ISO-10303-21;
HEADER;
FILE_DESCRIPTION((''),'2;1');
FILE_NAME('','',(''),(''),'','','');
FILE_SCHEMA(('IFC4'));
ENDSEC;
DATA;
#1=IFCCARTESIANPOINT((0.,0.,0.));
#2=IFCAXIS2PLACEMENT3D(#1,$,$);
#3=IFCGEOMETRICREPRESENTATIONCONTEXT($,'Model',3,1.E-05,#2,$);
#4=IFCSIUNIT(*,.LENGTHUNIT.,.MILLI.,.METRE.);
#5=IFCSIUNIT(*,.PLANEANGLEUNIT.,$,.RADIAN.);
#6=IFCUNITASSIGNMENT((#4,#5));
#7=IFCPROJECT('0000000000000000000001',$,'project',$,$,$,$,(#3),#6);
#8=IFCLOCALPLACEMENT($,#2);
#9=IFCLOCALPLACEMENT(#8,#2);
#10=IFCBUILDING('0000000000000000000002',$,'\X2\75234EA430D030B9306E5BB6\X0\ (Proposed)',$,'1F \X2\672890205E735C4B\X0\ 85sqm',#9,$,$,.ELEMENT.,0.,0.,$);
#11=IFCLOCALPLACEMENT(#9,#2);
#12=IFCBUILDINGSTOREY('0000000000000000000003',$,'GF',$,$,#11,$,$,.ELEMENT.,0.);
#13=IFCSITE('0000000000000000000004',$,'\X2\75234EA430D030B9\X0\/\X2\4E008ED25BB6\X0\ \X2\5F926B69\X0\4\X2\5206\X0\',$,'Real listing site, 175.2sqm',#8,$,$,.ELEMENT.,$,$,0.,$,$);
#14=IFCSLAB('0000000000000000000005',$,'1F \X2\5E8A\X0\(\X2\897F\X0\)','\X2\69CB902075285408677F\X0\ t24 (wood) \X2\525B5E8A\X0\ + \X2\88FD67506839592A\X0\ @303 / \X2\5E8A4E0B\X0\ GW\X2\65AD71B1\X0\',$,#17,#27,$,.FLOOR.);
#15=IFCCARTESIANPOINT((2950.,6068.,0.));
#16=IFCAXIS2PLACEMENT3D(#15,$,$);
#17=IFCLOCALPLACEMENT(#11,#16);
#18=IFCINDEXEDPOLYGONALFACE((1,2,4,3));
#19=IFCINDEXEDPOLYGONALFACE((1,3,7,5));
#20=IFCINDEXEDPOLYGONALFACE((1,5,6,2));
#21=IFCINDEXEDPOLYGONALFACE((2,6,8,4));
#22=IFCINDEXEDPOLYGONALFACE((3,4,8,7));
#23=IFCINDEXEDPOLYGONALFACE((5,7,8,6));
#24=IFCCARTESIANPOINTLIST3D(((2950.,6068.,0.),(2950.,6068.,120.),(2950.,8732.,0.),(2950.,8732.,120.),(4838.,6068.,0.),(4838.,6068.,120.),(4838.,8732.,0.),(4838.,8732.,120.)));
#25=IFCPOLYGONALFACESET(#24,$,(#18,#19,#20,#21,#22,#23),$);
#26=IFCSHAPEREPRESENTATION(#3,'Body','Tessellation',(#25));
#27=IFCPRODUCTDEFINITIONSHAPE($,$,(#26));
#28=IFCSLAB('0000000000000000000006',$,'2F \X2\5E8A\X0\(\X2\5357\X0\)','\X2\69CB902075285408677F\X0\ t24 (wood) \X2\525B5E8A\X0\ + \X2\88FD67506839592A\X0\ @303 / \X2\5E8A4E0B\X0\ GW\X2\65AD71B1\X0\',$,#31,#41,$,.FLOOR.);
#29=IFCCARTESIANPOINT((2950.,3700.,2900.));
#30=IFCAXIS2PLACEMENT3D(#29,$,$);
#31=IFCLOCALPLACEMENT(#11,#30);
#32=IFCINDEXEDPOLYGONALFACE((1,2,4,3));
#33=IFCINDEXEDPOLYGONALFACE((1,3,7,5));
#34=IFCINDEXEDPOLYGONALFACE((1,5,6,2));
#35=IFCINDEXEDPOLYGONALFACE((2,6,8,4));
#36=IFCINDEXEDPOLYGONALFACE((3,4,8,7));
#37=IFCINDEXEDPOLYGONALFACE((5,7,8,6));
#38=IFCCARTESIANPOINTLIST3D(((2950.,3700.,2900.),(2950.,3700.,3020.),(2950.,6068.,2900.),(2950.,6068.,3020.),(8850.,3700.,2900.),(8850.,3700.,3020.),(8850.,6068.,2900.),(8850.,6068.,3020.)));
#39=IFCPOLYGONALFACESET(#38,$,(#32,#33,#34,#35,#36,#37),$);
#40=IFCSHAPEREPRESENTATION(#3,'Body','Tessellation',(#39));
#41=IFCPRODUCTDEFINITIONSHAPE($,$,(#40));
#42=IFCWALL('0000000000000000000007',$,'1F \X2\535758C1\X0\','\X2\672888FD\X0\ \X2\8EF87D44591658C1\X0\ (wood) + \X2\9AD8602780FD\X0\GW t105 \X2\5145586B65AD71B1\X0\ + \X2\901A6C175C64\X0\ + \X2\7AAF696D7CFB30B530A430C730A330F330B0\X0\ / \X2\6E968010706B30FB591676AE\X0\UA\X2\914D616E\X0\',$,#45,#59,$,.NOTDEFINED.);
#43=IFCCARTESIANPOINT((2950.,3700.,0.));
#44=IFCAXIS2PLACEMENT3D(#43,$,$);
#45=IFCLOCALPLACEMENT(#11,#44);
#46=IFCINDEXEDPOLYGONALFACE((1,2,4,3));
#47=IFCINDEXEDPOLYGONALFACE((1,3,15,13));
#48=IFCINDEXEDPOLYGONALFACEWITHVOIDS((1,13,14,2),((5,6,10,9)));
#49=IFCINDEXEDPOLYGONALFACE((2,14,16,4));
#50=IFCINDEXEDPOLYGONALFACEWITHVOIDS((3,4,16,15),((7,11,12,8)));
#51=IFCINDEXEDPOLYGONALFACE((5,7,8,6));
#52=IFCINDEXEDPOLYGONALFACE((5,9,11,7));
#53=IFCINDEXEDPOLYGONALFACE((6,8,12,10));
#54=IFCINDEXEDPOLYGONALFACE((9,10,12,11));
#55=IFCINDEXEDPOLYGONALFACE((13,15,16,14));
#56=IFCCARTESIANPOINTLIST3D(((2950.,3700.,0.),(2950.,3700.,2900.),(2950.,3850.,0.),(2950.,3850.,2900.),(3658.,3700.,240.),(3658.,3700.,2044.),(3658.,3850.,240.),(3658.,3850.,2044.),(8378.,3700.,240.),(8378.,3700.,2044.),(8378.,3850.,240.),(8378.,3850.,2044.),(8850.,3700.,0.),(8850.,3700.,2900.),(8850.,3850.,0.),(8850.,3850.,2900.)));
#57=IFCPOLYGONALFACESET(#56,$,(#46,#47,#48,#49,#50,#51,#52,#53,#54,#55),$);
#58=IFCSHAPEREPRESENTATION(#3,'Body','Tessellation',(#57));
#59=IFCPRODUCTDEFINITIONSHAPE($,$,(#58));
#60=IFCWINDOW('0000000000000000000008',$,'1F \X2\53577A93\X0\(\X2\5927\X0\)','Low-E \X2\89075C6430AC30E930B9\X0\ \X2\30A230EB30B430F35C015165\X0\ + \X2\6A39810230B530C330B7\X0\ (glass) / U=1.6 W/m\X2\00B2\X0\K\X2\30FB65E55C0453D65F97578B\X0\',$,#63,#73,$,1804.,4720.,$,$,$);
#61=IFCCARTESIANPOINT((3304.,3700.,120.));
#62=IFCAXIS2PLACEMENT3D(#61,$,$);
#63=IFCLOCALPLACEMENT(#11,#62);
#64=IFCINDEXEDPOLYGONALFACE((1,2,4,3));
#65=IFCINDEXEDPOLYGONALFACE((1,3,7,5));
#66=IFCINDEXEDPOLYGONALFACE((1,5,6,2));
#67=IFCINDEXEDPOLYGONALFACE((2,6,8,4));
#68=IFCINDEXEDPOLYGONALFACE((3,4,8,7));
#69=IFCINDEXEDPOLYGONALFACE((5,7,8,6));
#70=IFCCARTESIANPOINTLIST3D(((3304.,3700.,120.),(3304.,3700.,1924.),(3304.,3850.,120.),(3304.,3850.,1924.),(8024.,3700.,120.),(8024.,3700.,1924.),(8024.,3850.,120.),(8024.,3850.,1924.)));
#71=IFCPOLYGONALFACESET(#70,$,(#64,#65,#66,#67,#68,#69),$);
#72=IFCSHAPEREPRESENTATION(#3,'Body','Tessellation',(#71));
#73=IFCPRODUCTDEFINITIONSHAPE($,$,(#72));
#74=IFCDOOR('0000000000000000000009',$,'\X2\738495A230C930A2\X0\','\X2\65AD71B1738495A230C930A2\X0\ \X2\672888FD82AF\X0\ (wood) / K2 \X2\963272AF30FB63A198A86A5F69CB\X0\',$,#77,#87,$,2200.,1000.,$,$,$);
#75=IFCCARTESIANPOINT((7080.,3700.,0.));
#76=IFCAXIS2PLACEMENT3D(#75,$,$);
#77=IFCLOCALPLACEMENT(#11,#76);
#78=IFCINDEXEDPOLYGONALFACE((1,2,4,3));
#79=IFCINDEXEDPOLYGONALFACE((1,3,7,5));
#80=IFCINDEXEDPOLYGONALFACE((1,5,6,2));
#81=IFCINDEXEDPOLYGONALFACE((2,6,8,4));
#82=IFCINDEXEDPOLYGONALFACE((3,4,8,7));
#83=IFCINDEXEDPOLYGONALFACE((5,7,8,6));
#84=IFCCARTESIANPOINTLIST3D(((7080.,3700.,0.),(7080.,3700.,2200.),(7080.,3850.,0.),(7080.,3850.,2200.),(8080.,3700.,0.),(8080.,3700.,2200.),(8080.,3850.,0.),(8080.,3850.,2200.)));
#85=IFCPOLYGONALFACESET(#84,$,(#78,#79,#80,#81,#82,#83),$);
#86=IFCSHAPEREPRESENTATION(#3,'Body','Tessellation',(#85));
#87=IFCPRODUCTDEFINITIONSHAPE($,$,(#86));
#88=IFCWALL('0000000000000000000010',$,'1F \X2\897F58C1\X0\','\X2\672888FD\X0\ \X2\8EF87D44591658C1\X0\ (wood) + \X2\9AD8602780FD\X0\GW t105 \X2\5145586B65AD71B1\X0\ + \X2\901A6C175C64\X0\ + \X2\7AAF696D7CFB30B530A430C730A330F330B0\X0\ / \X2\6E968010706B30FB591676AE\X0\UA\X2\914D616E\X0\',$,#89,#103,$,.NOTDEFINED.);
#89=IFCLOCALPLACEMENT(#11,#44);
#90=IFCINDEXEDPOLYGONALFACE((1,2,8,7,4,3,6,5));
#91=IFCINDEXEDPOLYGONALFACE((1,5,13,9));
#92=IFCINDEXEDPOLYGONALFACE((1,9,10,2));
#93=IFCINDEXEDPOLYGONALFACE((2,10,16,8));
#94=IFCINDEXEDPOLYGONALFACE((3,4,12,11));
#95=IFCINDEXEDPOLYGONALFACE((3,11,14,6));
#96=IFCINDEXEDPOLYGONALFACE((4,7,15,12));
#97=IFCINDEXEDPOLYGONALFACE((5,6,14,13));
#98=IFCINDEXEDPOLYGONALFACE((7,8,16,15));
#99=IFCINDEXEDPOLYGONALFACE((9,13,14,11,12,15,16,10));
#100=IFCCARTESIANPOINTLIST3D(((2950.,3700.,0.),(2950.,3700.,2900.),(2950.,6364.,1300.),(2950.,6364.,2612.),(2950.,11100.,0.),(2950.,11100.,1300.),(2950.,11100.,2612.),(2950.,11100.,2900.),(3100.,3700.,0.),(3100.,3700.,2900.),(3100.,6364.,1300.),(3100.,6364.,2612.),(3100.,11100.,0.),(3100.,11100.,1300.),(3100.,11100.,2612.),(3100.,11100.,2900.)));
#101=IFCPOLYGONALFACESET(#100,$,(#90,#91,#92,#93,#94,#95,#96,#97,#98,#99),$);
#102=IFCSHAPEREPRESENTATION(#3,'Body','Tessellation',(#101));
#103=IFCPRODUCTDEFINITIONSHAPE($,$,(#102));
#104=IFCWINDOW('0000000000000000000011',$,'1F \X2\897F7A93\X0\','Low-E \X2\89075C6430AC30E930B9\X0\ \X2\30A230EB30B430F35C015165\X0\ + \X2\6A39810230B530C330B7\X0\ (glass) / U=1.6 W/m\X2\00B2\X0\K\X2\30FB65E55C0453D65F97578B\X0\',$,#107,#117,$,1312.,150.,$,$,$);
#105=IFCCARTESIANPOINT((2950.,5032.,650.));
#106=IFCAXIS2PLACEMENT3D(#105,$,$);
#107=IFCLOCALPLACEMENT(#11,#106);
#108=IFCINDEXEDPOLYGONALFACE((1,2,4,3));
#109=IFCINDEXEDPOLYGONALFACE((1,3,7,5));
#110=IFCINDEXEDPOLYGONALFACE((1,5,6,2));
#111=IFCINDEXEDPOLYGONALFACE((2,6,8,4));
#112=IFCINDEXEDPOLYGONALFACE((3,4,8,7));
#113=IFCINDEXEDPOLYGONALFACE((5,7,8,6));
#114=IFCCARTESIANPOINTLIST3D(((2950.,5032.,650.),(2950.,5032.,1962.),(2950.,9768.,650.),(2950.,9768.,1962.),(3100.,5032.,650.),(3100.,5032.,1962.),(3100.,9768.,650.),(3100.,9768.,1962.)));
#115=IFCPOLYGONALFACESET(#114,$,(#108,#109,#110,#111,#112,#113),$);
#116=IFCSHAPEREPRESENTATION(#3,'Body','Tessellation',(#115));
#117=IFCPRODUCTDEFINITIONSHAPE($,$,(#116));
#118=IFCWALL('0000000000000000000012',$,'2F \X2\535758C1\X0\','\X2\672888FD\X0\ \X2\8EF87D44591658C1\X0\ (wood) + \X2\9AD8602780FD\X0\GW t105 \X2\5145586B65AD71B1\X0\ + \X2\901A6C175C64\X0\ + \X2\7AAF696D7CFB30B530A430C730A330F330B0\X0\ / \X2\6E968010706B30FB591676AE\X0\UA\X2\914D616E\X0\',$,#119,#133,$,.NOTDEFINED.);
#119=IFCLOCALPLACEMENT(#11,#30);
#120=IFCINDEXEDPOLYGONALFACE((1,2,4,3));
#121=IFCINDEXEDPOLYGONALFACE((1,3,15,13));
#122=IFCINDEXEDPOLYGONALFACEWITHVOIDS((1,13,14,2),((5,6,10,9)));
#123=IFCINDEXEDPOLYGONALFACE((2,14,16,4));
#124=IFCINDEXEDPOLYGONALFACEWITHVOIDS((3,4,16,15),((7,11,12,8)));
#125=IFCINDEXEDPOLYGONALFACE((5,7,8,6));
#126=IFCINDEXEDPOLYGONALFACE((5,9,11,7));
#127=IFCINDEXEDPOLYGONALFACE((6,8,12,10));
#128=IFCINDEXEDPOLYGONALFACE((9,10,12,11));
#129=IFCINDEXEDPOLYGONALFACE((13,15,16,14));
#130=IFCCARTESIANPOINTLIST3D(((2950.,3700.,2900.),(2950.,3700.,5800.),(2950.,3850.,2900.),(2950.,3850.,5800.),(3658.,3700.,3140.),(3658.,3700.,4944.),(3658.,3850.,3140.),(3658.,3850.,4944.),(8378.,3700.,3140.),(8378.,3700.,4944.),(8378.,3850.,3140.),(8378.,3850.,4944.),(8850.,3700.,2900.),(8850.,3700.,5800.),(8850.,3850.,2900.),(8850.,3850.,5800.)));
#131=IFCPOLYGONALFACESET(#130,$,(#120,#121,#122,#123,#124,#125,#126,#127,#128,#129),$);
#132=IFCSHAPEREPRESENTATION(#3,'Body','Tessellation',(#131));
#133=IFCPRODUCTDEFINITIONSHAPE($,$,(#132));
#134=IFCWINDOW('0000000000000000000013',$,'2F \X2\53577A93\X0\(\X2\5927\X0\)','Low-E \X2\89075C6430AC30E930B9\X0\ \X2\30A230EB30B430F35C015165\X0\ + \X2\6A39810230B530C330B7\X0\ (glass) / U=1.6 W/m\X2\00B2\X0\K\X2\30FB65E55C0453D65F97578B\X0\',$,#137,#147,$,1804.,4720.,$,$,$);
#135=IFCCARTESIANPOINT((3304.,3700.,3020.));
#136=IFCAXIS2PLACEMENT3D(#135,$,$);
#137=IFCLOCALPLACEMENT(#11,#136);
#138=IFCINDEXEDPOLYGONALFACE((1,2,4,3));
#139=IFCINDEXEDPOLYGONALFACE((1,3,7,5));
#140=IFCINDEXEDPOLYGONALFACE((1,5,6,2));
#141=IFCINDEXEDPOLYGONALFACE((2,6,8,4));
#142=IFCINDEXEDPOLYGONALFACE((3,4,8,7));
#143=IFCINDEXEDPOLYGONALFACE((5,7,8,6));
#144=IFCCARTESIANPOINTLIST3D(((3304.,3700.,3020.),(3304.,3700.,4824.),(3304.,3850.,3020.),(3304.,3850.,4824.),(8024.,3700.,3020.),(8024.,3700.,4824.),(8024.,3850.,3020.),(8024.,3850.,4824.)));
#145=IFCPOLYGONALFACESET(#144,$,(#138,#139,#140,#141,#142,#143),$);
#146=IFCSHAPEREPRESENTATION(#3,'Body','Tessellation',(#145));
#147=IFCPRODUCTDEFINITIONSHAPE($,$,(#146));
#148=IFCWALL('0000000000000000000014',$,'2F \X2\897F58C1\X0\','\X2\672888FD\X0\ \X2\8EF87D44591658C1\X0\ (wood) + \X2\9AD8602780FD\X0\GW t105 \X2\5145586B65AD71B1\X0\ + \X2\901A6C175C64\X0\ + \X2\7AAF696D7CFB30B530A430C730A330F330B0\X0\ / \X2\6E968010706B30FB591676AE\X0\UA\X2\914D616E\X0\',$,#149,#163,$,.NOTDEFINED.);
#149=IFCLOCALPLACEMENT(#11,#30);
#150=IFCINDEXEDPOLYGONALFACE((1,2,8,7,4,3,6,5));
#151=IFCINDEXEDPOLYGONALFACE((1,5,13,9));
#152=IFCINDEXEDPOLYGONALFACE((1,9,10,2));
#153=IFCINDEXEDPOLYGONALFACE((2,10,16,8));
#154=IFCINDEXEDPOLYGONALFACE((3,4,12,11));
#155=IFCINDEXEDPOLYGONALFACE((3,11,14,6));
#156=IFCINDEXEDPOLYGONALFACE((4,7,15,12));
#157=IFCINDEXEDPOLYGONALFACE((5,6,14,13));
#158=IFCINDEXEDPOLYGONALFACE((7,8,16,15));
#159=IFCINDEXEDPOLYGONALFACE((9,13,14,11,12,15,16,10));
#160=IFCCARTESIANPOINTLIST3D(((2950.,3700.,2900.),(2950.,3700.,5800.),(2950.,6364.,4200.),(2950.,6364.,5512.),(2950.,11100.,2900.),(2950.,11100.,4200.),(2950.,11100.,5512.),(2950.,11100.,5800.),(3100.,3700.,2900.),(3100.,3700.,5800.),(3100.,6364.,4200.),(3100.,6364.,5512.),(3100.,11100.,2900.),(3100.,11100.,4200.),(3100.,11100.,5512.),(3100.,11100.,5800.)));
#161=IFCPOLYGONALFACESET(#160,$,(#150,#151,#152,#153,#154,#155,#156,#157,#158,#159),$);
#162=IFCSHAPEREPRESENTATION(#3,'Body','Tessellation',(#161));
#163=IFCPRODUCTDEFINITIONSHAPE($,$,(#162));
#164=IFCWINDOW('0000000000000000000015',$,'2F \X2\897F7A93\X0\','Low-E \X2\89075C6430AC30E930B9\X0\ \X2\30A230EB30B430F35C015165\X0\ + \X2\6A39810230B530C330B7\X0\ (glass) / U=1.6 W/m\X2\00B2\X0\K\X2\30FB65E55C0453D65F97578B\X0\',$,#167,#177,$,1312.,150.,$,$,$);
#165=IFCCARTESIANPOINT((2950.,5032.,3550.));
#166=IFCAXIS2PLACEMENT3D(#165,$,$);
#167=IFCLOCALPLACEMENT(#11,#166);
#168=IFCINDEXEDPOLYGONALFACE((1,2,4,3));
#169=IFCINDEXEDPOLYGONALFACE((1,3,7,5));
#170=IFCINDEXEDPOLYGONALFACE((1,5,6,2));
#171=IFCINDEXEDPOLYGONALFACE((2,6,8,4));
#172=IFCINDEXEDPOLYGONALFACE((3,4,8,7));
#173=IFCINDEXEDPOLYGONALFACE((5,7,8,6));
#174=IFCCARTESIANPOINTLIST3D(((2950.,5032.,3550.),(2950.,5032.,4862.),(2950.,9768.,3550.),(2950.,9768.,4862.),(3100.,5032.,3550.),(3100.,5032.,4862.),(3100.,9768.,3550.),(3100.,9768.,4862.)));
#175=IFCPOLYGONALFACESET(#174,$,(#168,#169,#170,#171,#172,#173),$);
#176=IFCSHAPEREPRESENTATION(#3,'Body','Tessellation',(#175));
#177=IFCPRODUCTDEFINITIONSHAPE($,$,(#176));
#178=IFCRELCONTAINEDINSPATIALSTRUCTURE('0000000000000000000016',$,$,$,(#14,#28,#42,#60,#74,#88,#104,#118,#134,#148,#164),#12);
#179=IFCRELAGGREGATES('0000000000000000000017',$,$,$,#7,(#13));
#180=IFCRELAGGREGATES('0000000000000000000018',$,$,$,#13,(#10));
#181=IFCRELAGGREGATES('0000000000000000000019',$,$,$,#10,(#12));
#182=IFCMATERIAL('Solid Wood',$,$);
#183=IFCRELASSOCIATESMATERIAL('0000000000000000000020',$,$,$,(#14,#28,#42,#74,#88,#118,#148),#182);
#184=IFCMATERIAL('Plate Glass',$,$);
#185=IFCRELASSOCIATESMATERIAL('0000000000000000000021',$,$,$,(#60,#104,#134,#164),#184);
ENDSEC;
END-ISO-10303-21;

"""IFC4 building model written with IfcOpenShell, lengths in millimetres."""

from ifc_helpers import new_model, si_unit, frame, frame_2d, origin, place, context, project, spatial, rectangle, extrude, material, element, fill, save


model = new_model("IFC4")

# Units and contexts
model_context = context("Model", 3, precision=1e-05, world=origin())
ifc_project = project(units=[si_unit("LENGTHUNIT", "METRE", prefix="MILLI"), si_unit("PLANEANGLEUNIT", "RADIAN")], contexts=[model_context])

# Site, building, storey
site_placement = place(None, origin())
site = spatial("IfcSite", under=ifc_project, at=site_placement, Name="産交バス/一軒家 徒歩4分", ObjectType="Real listing site, 175.2sqm", CompositionType="ELEMENT", RefElevation=0.0)
building_placement = place(site_placement, origin())
building = spatial("IfcBuilding", under=site, at=building_placement, Name="産交バスの家 (Proposed)", ObjectType="1F 木造平屋 85sqm", CompositionType="ELEMENT", ElevationOfRefHeight=0.0, ElevationOfTerrain=0.0)
storey_placement = place(building_placement, origin())
storey = spatial("IfcBuildingStorey", under=building, at=storey_placement, Name="GF", CompositionType="ELEMENT", Elevation=0.0)

# Slabs
ifc_material_1 = material(Name="Solid Wood")
slab_1_placement = place(storey_placement, frame((2950.0, 6068.0, 0.0)))
element("IfcSlab", 1, at=slab_1_placement, inside=storey, material=ifc_material_1, Name="1F 床(西)", Description="構造用合板 t24 (wood) 剛床 + 製材根太 @303 / 床下 GW断熱", PredefinedType="FLOOR", context=model_context, shape_type="SweptSolid", body=[
    extrude(rectangle(XDim=1888.0, YDim=2664.0, at=frame_2d((944.0, 1332.0))), frame((2950.0, 6068.0, 0.0)), (0.0, 0.0, 1.0), 120.0),
])
slab_2_placement = place(storey_placement, frame((2950.0, 3700.0, 2900.0)))
element("IfcSlab", 2, at=slab_2_placement, inside=storey, material=ifc_material_1, Name="2F 床(南)", Description="構造用合板 t24 (wood) 剛床 + 製材根太 @303 / 床下 GW断熱", PredefinedType="FLOOR", context=model_context, shape_type="SweptSolid", body=[
    extrude(rectangle(XDim=5900.0, YDim=2368.0, at=frame_2d((2950.0, 1184.0))), frame((2950.0, 3700.0, 2900.0)), (0.0, 0.0, 1.0), 120.0),
])

# Wall, openings, window, door
wall_1_placement = place(storey_placement, frame((2950.0, 3700.0, 0.0)))
wall_1 = element("IfcWall", 3, at=wall_1_placement, inside=storey, material=ifc_material_1, Name="1F 南壁", Description="木製 軸組外壁 (wood) + 高性能GW t105 充填断熱 + 通気層 + 窯業系サイディング / 準耐火・外皮UA配慮", PredefinedType="NOTDEFINED", context=model_context, shape_type="SweptSolid", body=[
    extrude(rectangle(XDim=5900.0, YDim=150.0, at=frame_2d((2950.0, 75.0))), frame((2950.0, 3700.0, 0.0)), (0.0, 0.0, 1.0), 2900.0),
])
opening_1_placement = place(storey_placement, frame((3304.0, 3700.0, 120.0)))
opening_1 = element("IfcOpeningElement", 4, at=opening_1_placement, cuts=wall_1, PredefinedType="NOTDEFINED", context=model_context, shape_type="SweptSolid", body=[
    extrude(rectangle(XDim=4720.0, YDim=150.0, at=frame_2d((2360.0, 75.0))), frame((3304.0, 3700.0, 120.0)), (0.0, 0.0, 1.0), 1804.0),
])
opening_2_placement = place(storey_placement, frame((7080.0, 3700.0, 0.0)))
opening_2 = element("IfcOpeningElement", 5, at=opening_2_placement, cuts=wall_1, PredefinedType="NOTDEFINED", context=model_context, shape_type="SweptSolid", body=[
    extrude(rectangle(XDim=1000.0, YDim=150.0, at=frame_2d((500.0, 75.0))), frame((7080.0, 3700.0, 0.0)), (0.0, 0.0, 1.0), 2200.0),
])
ifc_material_2 = material(Name="Plate Glass")
window_1_placement = place(storey_placement, frame((3304.0, 3700.0, 120.0)))
window_1 = element("IfcWindow", 6, at=window_1_placement, inside=storey, material=ifc_material_2, Name="1F 南窓(大)", Description="Low-E 複層ガラス アルゴン封入 + 樹脂サッシ (glass) / U=1.6 W/m²K・日射取得型", OverallHeight=1804.0, OverallWidth=4720.0, context=model_context, shape_type="SweptSolid", body=[
    extrude(rectangle(XDim=4720.0, YDim=150.0, at=frame_2d((2360.0, 75.0))), frame((3304.0, 3700.0, 120.0)), (0.0, 0.0, 1.0), 1804.0),
])
fill(opening_1, window_1)
door_placement = place(storey_placement, frame((7080.0, 3700.0, 0.0)))
door = element("IfcDoor", 7, at=door_placement, inside=storey, material=ifc_material_1, Name="玄関ドア", Description="断熱玄関ドア 木製芯 (wood) / K2 防犯・採風機構", OverallHeight=2200.0, OverallWidth=1000.0, context=model_context, shape_type="SweptSolid", body=[
    extrude(rectangle(XDim=1000.0, YDim=150.0, at=frame_2d((500.0, 75.0))), frame((7080.0, 3700.0, 0.0)), (0.0, 0.0, 1.0), 2200.0),
])
fill(opening_2, door)

# Walls, openings, windows
wall_2_placement = place(storey_placement, frame((2950.0, 3700.0, 0.0)))
wall_2 = element("IfcWall", 8, at=wall_2_placement, inside=storey, material=ifc_material_1, Name="1F 西壁", Description="木製 軸組外壁 (wood) + 高性能GW t105 充填断熱 + 通気層 + 窯業系サイディング / 準耐火・外皮UA配慮", PredefinedType="NOTDEFINED", context=model_context, shape_type="SweptSolid", body=[
    extrude(rectangle(XDim=150.0, YDim=7400.0, at=frame_2d((75.0, 3700.0))), frame((2950.0, 3700.0, 0.0)), (0.0, 0.0, 1.0), 2900.0),
])
opening_3_placement = place(storey_placement, frame((2950.0, 5032.0, 650.0)))
opening_3 = element("IfcOpeningElement", 9, at=opening_3_placement, cuts=wall_2, PredefinedType="NOTDEFINED", context=model_context, shape_type="SweptSolid", body=[
    extrude(rectangle(XDim=150.0, YDim=4736.0, at=frame_2d((75.0, 2368.0))), frame((2950.0, 5032.0, 650.0)), (0.0, 0.0, 1.0), 1312.0),
])
window_2_placement = place(storey_placement, frame((2950.0, 5032.0, 650.0)))
window_2 = element("IfcWindow", 10, at=window_2_placement, inside=storey, material=ifc_material_2, Name="1F 西窓", Description="Low-E 複層ガラス アルゴン封入 + 樹脂サッシ (glass) / U=1.6 W/m²K・日射取得型", OverallHeight=1312.0, OverallWidth=150.0, context=model_context, shape_type="SweptSolid", body=[
    extrude(rectangle(XDim=150.0, YDim=4736.0, at=frame_2d((75.0, 2368.0))), frame((2950.0, 5032.0, 650.0)), (0.0, 0.0, 1.0), 1312.0),
])
fill(opening_3, window_2)
wall_3_placement = place(storey_placement, frame((2950.0, 3700.0, 2900.0)))
wall_3 = element("IfcWall", 11, at=wall_3_placement, inside=storey, material=ifc_material_1, Name="2F 南壁", Description="木製 軸組外壁 (wood) + 高性能GW t105 充填断熱 + 通気層 + 窯業系サイディング / 準耐火・外皮UA配慮", PredefinedType="NOTDEFINED", context=model_context, shape_type="SweptSolid", body=[
    extrude(rectangle(XDim=5900.0, YDim=150.0, at=frame_2d((2950.0, 75.0))), frame((2950.0, 3700.0, 2900.0)), (0.0, 0.0, 1.0), 2900.0),
])
opening_4_placement = place(storey_placement, frame((3304.0, 3700.0, 3020.0)))
opening_4 = element("IfcOpeningElement", 12, at=opening_4_placement, cuts=wall_3, PredefinedType="NOTDEFINED", context=model_context, shape_type="SweptSolid", body=[
    extrude(rectangle(XDim=4720.0, YDim=150.0, at=frame_2d((2360.0, 75.0))), frame((3304.0, 3700.0, 3020.0)), (0.0, 0.0, 1.0), 1804.0),
])
window_3_placement = place(storey_placement, frame((3304.0, 3700.0, 3020.0)))
window_3 = element("IfcWindow", 13, at=window_3_placement, inside=storey, material=ifc_material_2, Name="2F 南窓(大)", Description="Low-E 複層ガラス アルゴン封入 + 樹脂サッシ (glass) / U=1.6 W/m²K・日射取得型", OverallHeight=1804.0, OverallWidth=4720.0, context=model_context, shape_type="SweptSolid", body=[
    extrude(rectangle(XDim=4720.0, YDim=150.0, at=frame_2d((2360.0, 75.0))), frame((3304.0, 3700.0, 3020.0)), (0.0, 0.0, 1.0), 1804.0),
])
fill(opening_4, window_3)
wall_4_placement = place(storey_placement, frame((2950.0, 3700.0, 2900.0)))
wall_4 = element("IfcWall", 14, at=wall_4_placement, inside=storey, material=ifc_material_1, Name="2F 西壁", Description="木製 軸組外壁 (wood) + 高性能GW t105 充填断熱 + 通気層 + 窯業系サイディング / 準耐火・外皮UA配慮", PredefinedType="NOTDEFINED", context=model_context, shape_type="SweptSolid", body=[
    extrude(rectangle(XDim=150.0, YDim=7400.0, at=frame_2d((75.0, 3700.0))), frame((2950.0, 3700.0, 2900.0)), (0.0, 0.0, 1.0), 2900.0),
])
opening_5_placement = place(storey_placement, frame((2950.0, 5032.0, 3550.0)))
opening_5 = element("IfcOpeningElement", 15, at=opening_5_placement, cuts=wall_4, PredefinedType="NOTDEFINED", context=model_context, shape_type="SweptSolid", body=[
    extrude(rectangle(XDim=150.0, YDim=4736.0, at=frame_2d((75.0, 2368.0))), frame((2950.0, 5032.0, 3550.0)), (0.0, 0.0, 1.0), 1312.0),
])
window_4_placement = place(storey_placement, frame((2950.0, 5032.0, 3550.0)))
window_4 = element("IfcWindow", 16, at=window_4_placement, inside=storey, material=ifc_material_2, Name="2F 西窓", Description="Low-E 複層ガラス アルゴン封入 + 樹脂サッシ (glass) / U=1.6 W/m²K・日射取得型", OverallHeight=1312.0, OverallWidth=150.0, context=model_context, shape_type="SweptSolid", body=[
    extrude(rectangle(XDim=150.0, YDim=4736.0, at=frame_2d((75.0, 2368.0))), frame((2950.0, 5032.0, 3550.0)), (0.0, 0.0, 1.0), 1312.0),
])
fill(opening_5, window_4)

save(model, "model.ifc")
